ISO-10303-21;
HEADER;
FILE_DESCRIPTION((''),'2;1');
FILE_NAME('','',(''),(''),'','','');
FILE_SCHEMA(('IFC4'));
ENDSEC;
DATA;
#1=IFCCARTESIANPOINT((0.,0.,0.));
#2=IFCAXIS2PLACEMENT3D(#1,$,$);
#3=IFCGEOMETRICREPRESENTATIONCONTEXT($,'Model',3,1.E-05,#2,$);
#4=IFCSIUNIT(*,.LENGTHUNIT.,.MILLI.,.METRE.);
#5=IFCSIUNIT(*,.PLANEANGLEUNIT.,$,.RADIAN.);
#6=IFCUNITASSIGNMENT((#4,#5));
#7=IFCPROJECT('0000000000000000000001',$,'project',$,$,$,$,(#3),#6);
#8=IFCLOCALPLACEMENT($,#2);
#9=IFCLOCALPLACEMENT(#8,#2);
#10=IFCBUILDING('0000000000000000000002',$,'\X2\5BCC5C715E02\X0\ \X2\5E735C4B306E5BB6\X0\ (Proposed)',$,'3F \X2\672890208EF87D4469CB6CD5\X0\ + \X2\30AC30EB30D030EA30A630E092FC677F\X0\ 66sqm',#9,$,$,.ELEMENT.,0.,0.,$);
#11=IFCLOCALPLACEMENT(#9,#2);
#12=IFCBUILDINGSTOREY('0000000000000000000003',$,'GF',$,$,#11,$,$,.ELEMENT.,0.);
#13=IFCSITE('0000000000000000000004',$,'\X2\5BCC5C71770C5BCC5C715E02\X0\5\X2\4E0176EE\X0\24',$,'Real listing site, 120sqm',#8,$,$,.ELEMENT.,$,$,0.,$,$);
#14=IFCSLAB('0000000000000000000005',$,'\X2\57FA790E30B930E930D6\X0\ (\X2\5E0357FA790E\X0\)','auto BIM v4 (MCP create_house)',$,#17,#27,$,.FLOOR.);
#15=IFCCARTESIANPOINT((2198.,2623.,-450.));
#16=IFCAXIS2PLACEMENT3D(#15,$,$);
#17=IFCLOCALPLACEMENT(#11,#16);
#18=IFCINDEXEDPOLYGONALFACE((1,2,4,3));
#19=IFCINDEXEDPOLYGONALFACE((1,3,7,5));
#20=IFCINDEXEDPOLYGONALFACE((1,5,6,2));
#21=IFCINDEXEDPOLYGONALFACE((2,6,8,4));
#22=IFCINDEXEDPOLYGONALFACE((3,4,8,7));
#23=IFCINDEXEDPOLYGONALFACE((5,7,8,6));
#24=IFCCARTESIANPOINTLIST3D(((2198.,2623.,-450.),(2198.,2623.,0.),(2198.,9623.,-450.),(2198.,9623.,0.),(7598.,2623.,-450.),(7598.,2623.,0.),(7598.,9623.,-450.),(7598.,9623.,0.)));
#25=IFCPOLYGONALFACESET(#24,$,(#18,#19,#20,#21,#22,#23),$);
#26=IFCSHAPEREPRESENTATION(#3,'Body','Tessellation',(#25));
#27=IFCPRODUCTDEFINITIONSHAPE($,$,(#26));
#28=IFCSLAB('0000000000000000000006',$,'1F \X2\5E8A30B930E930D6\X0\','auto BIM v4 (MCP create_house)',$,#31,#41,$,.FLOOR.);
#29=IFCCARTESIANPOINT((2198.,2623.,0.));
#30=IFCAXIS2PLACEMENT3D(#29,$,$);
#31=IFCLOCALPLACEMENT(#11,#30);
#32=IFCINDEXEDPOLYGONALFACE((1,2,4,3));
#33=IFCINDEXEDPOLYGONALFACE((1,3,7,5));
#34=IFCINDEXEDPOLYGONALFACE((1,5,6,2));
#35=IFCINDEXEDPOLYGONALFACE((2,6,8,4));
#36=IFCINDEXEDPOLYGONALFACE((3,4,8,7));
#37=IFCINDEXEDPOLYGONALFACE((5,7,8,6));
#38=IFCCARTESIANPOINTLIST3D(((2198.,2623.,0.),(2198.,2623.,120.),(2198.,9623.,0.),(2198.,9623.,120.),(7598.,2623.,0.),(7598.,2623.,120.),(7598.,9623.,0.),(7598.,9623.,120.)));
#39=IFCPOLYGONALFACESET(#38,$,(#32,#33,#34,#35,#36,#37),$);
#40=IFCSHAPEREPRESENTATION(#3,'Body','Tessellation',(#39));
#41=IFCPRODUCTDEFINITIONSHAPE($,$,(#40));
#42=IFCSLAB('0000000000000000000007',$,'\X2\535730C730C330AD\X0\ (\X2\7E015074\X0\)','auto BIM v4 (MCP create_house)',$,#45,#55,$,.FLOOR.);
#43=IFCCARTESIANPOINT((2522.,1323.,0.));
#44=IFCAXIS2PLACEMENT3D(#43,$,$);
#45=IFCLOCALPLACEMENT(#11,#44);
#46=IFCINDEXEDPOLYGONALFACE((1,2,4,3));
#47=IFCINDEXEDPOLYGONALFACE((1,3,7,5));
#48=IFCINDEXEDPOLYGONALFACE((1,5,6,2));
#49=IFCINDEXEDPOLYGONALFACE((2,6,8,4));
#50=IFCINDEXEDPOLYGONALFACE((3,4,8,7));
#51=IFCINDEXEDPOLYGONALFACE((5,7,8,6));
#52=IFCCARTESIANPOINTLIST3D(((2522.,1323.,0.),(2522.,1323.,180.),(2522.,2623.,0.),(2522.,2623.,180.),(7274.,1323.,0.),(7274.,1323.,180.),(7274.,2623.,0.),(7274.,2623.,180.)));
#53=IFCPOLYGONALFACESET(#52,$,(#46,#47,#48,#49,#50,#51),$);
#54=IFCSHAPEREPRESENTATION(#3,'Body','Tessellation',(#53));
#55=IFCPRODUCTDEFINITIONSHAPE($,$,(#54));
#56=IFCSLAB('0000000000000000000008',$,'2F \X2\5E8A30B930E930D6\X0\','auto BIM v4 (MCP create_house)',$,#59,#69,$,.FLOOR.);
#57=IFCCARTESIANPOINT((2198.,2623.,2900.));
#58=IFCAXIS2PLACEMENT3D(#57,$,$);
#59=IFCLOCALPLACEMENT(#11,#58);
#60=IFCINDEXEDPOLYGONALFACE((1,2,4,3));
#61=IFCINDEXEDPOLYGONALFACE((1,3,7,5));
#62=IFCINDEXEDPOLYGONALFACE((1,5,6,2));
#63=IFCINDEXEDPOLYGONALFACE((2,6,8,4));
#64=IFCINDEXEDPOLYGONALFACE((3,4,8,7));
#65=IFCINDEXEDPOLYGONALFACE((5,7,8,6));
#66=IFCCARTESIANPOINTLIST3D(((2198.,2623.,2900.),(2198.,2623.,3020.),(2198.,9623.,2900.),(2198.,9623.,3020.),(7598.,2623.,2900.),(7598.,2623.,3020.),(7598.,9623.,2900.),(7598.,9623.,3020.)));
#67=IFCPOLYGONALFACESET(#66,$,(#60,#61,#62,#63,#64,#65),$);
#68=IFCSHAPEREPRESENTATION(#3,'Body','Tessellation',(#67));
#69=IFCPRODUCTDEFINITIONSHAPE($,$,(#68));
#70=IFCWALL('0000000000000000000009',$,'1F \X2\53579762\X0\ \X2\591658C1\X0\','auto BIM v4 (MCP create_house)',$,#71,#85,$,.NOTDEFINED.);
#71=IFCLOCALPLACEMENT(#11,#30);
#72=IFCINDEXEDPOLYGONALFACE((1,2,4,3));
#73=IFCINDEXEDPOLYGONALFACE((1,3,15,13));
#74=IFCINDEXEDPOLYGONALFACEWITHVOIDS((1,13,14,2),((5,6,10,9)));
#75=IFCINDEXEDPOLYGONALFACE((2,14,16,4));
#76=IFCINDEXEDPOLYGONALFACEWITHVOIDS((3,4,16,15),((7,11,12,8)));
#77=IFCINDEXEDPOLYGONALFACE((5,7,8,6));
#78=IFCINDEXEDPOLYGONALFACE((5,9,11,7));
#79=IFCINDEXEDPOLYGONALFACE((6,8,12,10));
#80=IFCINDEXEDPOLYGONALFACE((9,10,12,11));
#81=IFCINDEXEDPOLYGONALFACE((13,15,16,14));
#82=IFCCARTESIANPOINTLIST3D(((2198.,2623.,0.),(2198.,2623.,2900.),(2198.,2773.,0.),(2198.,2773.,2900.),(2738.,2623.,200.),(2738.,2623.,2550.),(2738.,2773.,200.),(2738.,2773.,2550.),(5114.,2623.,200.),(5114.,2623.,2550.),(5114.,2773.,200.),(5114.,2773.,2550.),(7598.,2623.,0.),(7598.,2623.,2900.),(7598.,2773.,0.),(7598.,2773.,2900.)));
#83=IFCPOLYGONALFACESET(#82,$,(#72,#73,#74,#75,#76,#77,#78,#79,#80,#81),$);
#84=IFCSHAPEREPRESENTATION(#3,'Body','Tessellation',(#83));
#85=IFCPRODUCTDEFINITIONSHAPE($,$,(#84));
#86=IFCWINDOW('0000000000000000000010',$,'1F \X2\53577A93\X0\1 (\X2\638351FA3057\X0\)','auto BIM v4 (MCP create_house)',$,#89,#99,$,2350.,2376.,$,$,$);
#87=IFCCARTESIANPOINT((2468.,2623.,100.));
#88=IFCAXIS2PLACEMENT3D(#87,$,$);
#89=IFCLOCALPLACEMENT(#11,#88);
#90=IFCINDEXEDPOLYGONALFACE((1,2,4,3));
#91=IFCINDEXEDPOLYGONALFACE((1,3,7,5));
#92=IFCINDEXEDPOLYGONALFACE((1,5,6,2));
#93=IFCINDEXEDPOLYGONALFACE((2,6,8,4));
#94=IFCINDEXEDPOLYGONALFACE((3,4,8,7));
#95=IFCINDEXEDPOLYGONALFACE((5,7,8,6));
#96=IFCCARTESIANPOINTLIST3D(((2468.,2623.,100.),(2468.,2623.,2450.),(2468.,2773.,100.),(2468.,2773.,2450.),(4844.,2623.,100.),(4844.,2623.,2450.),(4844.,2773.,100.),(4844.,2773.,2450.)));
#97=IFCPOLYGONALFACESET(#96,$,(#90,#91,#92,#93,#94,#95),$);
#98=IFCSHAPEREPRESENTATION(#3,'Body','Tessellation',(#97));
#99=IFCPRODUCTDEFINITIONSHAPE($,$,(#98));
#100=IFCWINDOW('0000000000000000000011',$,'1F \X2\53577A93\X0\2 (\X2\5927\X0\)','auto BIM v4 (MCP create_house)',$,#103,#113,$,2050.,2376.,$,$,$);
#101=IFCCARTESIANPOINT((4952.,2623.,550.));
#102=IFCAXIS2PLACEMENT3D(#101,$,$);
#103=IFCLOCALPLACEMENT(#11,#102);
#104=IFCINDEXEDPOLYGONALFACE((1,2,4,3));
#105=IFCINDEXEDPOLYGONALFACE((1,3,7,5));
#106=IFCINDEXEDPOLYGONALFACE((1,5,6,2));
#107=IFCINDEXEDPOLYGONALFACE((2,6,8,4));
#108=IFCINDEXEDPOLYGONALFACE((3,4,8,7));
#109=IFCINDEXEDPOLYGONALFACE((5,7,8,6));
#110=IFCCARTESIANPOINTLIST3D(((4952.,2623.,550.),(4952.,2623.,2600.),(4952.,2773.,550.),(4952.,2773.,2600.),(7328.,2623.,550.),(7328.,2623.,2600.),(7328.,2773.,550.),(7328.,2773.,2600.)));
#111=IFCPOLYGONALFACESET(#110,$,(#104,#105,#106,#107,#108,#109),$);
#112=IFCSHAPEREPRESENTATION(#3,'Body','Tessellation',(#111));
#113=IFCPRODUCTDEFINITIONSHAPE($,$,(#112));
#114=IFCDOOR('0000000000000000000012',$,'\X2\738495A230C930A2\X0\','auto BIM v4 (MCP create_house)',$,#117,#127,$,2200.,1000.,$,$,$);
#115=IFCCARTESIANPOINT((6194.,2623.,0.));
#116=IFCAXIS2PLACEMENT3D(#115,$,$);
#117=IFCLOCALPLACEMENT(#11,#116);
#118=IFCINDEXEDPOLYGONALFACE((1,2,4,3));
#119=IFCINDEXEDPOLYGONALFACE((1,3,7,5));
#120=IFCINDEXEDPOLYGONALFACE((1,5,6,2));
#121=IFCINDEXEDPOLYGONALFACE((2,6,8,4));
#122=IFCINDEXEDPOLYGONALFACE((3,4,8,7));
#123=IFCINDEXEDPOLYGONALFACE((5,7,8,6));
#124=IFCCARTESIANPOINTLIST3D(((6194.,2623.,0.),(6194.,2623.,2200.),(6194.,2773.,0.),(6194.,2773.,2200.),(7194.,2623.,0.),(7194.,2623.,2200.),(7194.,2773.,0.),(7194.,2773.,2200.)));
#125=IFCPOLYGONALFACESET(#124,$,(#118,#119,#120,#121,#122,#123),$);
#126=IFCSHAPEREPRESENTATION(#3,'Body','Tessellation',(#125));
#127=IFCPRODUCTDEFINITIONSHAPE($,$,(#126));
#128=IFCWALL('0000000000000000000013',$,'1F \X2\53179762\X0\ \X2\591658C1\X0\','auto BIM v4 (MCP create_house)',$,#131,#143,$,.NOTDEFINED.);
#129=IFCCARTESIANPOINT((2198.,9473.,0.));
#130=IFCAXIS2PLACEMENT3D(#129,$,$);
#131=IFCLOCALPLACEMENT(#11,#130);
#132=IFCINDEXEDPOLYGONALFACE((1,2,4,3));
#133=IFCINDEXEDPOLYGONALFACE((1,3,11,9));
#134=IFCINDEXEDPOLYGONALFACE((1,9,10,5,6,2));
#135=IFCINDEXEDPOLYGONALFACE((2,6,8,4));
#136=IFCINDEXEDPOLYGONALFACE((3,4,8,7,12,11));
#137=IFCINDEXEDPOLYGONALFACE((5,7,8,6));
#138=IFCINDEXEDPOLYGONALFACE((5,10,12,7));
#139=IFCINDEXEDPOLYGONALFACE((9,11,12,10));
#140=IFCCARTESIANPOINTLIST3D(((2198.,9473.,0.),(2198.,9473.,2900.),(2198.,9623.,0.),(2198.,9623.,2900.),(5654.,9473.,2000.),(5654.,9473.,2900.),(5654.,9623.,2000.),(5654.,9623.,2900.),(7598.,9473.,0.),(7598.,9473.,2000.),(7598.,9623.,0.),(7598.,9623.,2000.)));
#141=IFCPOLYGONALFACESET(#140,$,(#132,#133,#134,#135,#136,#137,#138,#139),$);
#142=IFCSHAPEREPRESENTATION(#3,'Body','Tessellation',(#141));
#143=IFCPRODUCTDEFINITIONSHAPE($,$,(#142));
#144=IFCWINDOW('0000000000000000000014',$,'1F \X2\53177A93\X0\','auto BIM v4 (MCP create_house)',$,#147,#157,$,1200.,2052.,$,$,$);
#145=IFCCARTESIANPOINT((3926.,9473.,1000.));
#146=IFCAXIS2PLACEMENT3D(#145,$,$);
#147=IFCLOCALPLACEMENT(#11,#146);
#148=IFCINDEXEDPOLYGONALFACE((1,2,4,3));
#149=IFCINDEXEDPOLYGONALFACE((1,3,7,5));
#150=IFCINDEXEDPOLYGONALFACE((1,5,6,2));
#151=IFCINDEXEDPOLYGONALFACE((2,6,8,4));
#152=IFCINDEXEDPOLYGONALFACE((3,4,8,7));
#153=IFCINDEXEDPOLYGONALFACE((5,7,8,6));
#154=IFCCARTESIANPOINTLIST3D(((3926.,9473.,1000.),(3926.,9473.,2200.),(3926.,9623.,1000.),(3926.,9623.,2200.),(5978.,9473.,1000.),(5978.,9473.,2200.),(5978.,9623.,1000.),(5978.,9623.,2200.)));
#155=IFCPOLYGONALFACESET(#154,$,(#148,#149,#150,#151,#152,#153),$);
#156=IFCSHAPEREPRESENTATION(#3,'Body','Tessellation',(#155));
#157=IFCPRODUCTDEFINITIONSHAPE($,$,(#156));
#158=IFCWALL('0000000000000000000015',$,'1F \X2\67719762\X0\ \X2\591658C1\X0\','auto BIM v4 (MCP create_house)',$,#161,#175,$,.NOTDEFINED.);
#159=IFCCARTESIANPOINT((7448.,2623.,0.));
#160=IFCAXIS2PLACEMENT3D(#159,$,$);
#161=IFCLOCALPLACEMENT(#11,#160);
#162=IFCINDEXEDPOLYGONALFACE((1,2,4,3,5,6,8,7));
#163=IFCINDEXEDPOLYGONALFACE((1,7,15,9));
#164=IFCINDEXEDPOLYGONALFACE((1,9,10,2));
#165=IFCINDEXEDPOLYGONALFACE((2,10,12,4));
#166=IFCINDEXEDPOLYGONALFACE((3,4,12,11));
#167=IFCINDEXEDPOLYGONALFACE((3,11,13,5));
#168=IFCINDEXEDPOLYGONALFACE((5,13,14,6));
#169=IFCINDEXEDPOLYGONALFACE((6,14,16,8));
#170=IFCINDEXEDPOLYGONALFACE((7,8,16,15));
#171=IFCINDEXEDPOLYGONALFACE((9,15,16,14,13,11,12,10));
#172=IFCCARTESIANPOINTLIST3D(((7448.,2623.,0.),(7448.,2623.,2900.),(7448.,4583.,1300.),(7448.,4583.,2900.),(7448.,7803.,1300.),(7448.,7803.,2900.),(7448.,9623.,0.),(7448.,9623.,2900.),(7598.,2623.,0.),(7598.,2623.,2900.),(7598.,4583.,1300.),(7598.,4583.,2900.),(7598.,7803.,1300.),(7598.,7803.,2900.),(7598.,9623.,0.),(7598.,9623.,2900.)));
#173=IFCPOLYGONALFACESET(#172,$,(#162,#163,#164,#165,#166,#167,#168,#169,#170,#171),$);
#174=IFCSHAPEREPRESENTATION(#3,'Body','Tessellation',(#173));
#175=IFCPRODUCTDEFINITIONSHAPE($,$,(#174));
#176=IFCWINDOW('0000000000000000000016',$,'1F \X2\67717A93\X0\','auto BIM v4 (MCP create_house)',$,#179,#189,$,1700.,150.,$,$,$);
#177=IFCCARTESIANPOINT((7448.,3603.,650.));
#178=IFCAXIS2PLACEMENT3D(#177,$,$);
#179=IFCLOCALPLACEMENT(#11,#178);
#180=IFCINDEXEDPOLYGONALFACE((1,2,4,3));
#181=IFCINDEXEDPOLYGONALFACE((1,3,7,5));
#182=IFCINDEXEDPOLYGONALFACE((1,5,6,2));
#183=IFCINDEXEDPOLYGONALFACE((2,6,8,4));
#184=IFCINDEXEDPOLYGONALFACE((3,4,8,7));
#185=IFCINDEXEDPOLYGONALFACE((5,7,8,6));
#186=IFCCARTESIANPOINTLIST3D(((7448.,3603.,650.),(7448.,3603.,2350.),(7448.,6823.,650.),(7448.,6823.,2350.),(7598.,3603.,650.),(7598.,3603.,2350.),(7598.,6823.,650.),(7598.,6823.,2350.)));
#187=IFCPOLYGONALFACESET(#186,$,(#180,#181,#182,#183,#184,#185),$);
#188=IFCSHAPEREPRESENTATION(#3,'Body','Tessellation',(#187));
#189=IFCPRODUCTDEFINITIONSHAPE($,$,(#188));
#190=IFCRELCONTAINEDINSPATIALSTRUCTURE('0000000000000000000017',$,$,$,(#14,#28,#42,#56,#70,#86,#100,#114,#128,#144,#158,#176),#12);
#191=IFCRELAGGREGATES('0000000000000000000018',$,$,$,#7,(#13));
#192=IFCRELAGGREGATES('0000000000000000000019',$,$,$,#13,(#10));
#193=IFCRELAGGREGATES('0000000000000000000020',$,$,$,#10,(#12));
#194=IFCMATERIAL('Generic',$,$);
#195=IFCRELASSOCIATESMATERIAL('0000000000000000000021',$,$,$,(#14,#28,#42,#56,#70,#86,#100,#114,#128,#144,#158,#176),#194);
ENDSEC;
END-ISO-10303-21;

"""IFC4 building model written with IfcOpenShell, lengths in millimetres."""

from ifc_helpers import new_model, si_unit, frame, frame_2d, origin, place, context, project, spatial, rectangle, extrude, material, element, fill, save


model = new_model("IFC4")

# Units and contexts
model_context = context("Model", 3, precision=1e-05, world=origin())
ifc_project = project(units=[si_unit("LENGTHUNIT", "METRE", prefix="MILLI"), si_unit("PLANEANGLEUNIT", "RADIAN")], contexts=[model_context])

# Site, building, storey
site_placement = place(None, origin())
site = spatial("IfcSite", under=ifc_project, at=site_placement, Name="富山県富山市5丁目24", ObjectType="Real listing site, 120sqm", CompositionType="ELEMENT", RefElevation=0.0)
building_placement = place(site_placement, origin())
building = spatial("IfcBuilding", under=site, at=building_placement, Name="富山市 平屋の家 (Proposed)", ObjectType="3F 木造軸組構法 + ガルバリウム鋼板 66sqm", CompositionType="ELEMENT", ElevationOfRefHeight=0.0, ElevationOfTerrain=0.0)
storey_placement = place(building_placement, origin())
storey = spatial("IfcBuildingStorey", under=building, at=storey_placement, Name="GF", CompositionType="ELEMENT", Elevation=0.0)

# Slabs
ifc_material = material(Name="Generic")
slab_1_placement = place(storey_placement, frame((2198.0, 2623.0, -450.0)))
element("IfcSlab", 1, at=slab_1_placement, inside=storey, material=ifc_material, Name="基礎スラブ (布基礎)", Description="auto BIM v4 (MCP create_house)", PredefinedType="FLOOR", context=model_context, shape_type="SweptSolid", body=[
    extrude(rectangle(XDim=5400.0, YDim=7000.0, at=frame_2d((2700.0, 3500.0))), frame((2198.0, 2623.0, -450.0)), (0.0, 0.0, 1.0), 450.0),
])
slab_2_placement = place(storey_placement, frame((2198.0, 2623.0, 0.0)))
element("IfcSlab", 2, at=slab_2_placement, inside=storey, material=ifc_material, Name="1F 床スラブ", Description="auto BIM v4 (MCP create_house)", PredefinedType="FLOOR", context=model_context, shape_type="SweptSolid", body=[
    extrude(rectangle(XDim=5400.0, YDim=7000.0, at=frame_2d((2700.0, 3500.0))), frame((2198.0, 2623.0, 0.0)), (0.0, 0.0, 1.0), 120.0),
])
slab_3_placement = place(storey_placement, frame((2522.0, 1323.0, 0.0)))
element("IfcSlab", 3, at=slab_3_placement, inside=storey, material=ifc_material, Name="南デッキ (縁側)", Description="auto BIM v4 (MCP create_house)", PredefinedType="FLOOR", context=model_context, shape_type="SweptSolid", body=[
    extrude(rectangle(XDim=4752.0, YDim=1300.0, at=frame_2d((2376.0, 650.0))), frame((2522.0, 1323.0, 0.0)), (0.0, 0.0, 1.0), 180.0),
])
slab_4_placement = place(storey_placement, frame((2198.0, 2623.0, 2900.0)))
element("IfcSlab", 4, at=slab_4_placement, inside=storey, material=ifc_material, Name="2F 床スラブ", Description="auto BIM v4 (MCP create_house)", PredefinedType="FLOOR", context=model_context, shape_type="SweptSolid", body=[
    extrude(rectangle(XDim=5400.0, YDim=7000.0, at=frame_2d((2700.0, 3500.0))), frame((2198.0, 2623.0, 2900.0)), (0.0, 0.0, 1.0), 120.0),
])

# Wall, openings, windows, door
wall_1_placement = place(storey_placement, frame((2198.0, 2623.0, 0.0)))
wall_1 = element("IfcWall", 5, at=wall_1_placement, inside=storey, material=ifc_material, Name="1F 南面 外壁", Description="auto BIM v4 (MCP create_house)", PredefinedType="NOTDEFINED", context=model_context, shape_type="SweptSolid", body=[
    extrude(rectangle(XDim=5400.0, YDim=150.0, at=frame_2d((2700.0, 75.0))), frame((2198.0, 2623.0, 0.0)), (0.0, 0.0, 1.0), 2900.0),
])
opening_1_placement = place(storey_placement, frame((2468.0, 2623.0, 100.0)))
opening_1 = element("IfcOpeningElement", 6, at=opening_1_placement, cuts=wall_1, PredefinedType="NOTDEFINED", context=model_context, shape_type="SweptSolid", body=[
    extrude(rectangle(XDim=2376.0, YDim=150.0, at=frame_2d((1188.0, 75.0))), frame((2468.0, 2623.0, 100.0)), (0.0, 0.0, 1.0), 2350.0),
])
opening_2_placement = place(storey_placement, frame((4952.0, 2623.0, 550.0)))
opening_2 = element("IfcOpeningElement", 7, at=opening_2_placement, cuts=wall_1, PredefinedType="NOTDEFINED", context=model_context, shape_type="SweptSolid", body=[
    extrude(rectangle(XDim=2376.0, YDim=150.0, at=frame_2d((1188.0, 75.0))), frame((4952.0, 2623.0, 550.0)), (0.0, 0.0, 1.0), 2050.0),
])
opening_3_placement = place(storey_placement, frame((6194.0, 2623.0, 0.0)))
opening_3 = element("IfcOpeningElement", 8, at=opening_3_placement, cuts=wall_1, PredefinedType="NOTDEFINED", context=model_context, shape_type="SweptSolid", body=[
    extrude(rectangle(XDim=1000.0, YDim=150.0, at=frame_2d((500.0, 75.0))), frame((6194.0, 2623.0, 0.0)), (0.0, 0.0, 1.0), 2200.0),
])
window_1_placement = place(storey_placement, frame((2468.0, 2623.0, 100.0)))
window_1 = element("IfcWindow", 9, at=window_1_placement, inside=storey, material=ifc_material, Name="1F 南窓1 (掃出し)", Description="auto BIM v4 (MCP create_house)", OverallHeight=2350.0, OverallWidth=2376.0, context=model_context, shape_type="SweptSolid", body=[
    extrude(rectangle(XDim=2376.0, YDim=150.0, at=frame_2d((1188.0, 75.0))), frame((2468.0, 2623.0, 100.0)), (0.0, 0.0, 1.0), 2350.0),
])
fill(opening_1, window_1)
window_2_placement = place(storey_placement, frame((4952.0, 2623.0, 550.0)))
window_2 = element("IfcWindow", 10, at=window_2_placement, inside=storey, material=ifc_material, Name="1F 南窓2 (大)", Description="auto BIM v4 (MCP create_house)", OverallHeight=2050.0, OverallWidth=2376.0, context=model_context, shape_type="SweptSolid", body=[
    extrude(rectangle(XDim=2376.0, YDim=150.0, at=frame_2d((1188.0, 75.0))), frame((4952.0, 2623.0, 550.0)), (0.0, 0.0, 1.0), 2050.0),
])
fill(opening_2, window_2)
door_placement = place(storey_placement, frame((6194.0, 2623.0, 0.0)))
door = element("IfcDoor", 11, at=door_placement, inside=storey, material=ifc_material, Name="玄関ドア", Description="auto BIM v4 (MCP create_house)", OverallHeight=2200.0, OverallWidth=1000.0, context=model_context, shape_type="SweptSolid", body=[
    extrude(rectangle(XDim=1000.0, YDim=150.0, at=frame_2d((500.0, 75.0))), frame((6194.0, 2623.0, 0.0)), (0.0, 0.0, 1.0), 2200.0),
])
fill(opening_3, door)

# Walls, openings, windows
wall_2_placement = place(storey_placement, frame((2198.0, 9473.0, 0.0)))
wall_2 = element("IfcWall", 12, at=wall_2_placement, inside=storey, material=ifc_material, Name="1F 北面 外壁", Description="auto BIM v4 (MCP create_house)", PredefinedType="NOTDEFINED", context=model_context, shape_type="SweptSolid", body=[
    extrude(rectangle(XDim=5400.0, YDim=150.0, at=frame_2d((2700.0, 75.0))), frame((2198.0, 9473.0, 0.0)), (0.0, 0.0, 1.0), 2900.0),
])
opening_4_placement = place(storey_placement, frame((3926.0, 9473.0, 1000.0)))
opening_4 = element("IfcOpeningElement", 13, at=opening_4_placement, cuts=wall_2, PredefinedType="NOTDEFINED", context=model_context, shape_type="SweptSolid", body=[
    extrude(rectangle(XDim=2052.0, YDim=150.0, at=frame_2d((1026.0, 75.0))), frame((3926.0, 9473.0, 1000.0)), (0.0, 0.0, 1.0), 1200.0),
])
window_3_placement = place(storey_placement, frame((3926.0, 9473.0, 1000.0)))
window_3 = element("IfcWindow", 14, at=window_3_placement, inside=storey, material=ifc_material, Name="1F 北窓", Description="auto BIM v4 (MCP create_house)", OverallHeight=1200.0, OverallWidth=2052.0, context=model_context, shape_type="SweptSolid", body=[
    extrude(rectangle(XDim=2052.0, YDim=150.0, at=frame_2d((1026.0, 75.0))), frame((3926.0, 9473.0, 1000.0)), (0.0, 0.0, 1.0), 1200.0),
])
fill(opening_4, window_3)
wall_3_placement = place(storey_placement, frame((7448.0, 2623.0, 0.0)))
wall_3 = element("IfcWall", 15, at=wall_3_placement, inside=storey, material=ifc_material, Name="1F 東面 外壁", Description="auto BIM v4 (MCP create_house)", PredefinedType="NOTDEFINED", context=model_context, shape_type="SweptSolid", body=[
    extrude(rectangle(XDim=150.0, YDim=7000.0, at=frame_2d((75.0, 3500.0))), frame((7448.0, 2623.0, 0.0)), (0.0, 0.0, 1.0), 2900.0),
])
opening_5_placement = place(storey_placement, frame((7448.0, 3603.0, 650.0)))
opening_5 = element("IfcOpeningElement", 16, at=opening_5_placement, cuts=wall_3, PredefinedType="NOTDEFINED", context=model_context, shape_type="SweptSolid", body=[
    extrude(rectangle(XDim=150.0, YDim=3220.0, at=frame_2d((75.0, 1610.0))), frame((7448.0, 3603.0, 650.0)), (0.0, 0.0, 1.0), 1700.0),
])
window_4_placement = place(storey_placement, frame((7448.0, 3603.0, 650.0)))
window_4 = element("IfcWindow", 17, at=window_4_placement, inside=storey, material=ifc_material, Name="1F 東窓", Description="auto BIM v4 (MCP create_house)", OverallHeight=1700.0, OverallWidth=150.0, context=model_context, shape_type="SweptSolid", body=[
    extrude(rectangle(XDim=150.0, YDim=3220.0, at=frame_2d((75.0, 1610.0))), frame((7448.0, 3603.0, 650.0)), (0.0, 0.0, 1.0), 1700.0),
])
fill(opening_5, window_4)

save(model, "model.ifc")
